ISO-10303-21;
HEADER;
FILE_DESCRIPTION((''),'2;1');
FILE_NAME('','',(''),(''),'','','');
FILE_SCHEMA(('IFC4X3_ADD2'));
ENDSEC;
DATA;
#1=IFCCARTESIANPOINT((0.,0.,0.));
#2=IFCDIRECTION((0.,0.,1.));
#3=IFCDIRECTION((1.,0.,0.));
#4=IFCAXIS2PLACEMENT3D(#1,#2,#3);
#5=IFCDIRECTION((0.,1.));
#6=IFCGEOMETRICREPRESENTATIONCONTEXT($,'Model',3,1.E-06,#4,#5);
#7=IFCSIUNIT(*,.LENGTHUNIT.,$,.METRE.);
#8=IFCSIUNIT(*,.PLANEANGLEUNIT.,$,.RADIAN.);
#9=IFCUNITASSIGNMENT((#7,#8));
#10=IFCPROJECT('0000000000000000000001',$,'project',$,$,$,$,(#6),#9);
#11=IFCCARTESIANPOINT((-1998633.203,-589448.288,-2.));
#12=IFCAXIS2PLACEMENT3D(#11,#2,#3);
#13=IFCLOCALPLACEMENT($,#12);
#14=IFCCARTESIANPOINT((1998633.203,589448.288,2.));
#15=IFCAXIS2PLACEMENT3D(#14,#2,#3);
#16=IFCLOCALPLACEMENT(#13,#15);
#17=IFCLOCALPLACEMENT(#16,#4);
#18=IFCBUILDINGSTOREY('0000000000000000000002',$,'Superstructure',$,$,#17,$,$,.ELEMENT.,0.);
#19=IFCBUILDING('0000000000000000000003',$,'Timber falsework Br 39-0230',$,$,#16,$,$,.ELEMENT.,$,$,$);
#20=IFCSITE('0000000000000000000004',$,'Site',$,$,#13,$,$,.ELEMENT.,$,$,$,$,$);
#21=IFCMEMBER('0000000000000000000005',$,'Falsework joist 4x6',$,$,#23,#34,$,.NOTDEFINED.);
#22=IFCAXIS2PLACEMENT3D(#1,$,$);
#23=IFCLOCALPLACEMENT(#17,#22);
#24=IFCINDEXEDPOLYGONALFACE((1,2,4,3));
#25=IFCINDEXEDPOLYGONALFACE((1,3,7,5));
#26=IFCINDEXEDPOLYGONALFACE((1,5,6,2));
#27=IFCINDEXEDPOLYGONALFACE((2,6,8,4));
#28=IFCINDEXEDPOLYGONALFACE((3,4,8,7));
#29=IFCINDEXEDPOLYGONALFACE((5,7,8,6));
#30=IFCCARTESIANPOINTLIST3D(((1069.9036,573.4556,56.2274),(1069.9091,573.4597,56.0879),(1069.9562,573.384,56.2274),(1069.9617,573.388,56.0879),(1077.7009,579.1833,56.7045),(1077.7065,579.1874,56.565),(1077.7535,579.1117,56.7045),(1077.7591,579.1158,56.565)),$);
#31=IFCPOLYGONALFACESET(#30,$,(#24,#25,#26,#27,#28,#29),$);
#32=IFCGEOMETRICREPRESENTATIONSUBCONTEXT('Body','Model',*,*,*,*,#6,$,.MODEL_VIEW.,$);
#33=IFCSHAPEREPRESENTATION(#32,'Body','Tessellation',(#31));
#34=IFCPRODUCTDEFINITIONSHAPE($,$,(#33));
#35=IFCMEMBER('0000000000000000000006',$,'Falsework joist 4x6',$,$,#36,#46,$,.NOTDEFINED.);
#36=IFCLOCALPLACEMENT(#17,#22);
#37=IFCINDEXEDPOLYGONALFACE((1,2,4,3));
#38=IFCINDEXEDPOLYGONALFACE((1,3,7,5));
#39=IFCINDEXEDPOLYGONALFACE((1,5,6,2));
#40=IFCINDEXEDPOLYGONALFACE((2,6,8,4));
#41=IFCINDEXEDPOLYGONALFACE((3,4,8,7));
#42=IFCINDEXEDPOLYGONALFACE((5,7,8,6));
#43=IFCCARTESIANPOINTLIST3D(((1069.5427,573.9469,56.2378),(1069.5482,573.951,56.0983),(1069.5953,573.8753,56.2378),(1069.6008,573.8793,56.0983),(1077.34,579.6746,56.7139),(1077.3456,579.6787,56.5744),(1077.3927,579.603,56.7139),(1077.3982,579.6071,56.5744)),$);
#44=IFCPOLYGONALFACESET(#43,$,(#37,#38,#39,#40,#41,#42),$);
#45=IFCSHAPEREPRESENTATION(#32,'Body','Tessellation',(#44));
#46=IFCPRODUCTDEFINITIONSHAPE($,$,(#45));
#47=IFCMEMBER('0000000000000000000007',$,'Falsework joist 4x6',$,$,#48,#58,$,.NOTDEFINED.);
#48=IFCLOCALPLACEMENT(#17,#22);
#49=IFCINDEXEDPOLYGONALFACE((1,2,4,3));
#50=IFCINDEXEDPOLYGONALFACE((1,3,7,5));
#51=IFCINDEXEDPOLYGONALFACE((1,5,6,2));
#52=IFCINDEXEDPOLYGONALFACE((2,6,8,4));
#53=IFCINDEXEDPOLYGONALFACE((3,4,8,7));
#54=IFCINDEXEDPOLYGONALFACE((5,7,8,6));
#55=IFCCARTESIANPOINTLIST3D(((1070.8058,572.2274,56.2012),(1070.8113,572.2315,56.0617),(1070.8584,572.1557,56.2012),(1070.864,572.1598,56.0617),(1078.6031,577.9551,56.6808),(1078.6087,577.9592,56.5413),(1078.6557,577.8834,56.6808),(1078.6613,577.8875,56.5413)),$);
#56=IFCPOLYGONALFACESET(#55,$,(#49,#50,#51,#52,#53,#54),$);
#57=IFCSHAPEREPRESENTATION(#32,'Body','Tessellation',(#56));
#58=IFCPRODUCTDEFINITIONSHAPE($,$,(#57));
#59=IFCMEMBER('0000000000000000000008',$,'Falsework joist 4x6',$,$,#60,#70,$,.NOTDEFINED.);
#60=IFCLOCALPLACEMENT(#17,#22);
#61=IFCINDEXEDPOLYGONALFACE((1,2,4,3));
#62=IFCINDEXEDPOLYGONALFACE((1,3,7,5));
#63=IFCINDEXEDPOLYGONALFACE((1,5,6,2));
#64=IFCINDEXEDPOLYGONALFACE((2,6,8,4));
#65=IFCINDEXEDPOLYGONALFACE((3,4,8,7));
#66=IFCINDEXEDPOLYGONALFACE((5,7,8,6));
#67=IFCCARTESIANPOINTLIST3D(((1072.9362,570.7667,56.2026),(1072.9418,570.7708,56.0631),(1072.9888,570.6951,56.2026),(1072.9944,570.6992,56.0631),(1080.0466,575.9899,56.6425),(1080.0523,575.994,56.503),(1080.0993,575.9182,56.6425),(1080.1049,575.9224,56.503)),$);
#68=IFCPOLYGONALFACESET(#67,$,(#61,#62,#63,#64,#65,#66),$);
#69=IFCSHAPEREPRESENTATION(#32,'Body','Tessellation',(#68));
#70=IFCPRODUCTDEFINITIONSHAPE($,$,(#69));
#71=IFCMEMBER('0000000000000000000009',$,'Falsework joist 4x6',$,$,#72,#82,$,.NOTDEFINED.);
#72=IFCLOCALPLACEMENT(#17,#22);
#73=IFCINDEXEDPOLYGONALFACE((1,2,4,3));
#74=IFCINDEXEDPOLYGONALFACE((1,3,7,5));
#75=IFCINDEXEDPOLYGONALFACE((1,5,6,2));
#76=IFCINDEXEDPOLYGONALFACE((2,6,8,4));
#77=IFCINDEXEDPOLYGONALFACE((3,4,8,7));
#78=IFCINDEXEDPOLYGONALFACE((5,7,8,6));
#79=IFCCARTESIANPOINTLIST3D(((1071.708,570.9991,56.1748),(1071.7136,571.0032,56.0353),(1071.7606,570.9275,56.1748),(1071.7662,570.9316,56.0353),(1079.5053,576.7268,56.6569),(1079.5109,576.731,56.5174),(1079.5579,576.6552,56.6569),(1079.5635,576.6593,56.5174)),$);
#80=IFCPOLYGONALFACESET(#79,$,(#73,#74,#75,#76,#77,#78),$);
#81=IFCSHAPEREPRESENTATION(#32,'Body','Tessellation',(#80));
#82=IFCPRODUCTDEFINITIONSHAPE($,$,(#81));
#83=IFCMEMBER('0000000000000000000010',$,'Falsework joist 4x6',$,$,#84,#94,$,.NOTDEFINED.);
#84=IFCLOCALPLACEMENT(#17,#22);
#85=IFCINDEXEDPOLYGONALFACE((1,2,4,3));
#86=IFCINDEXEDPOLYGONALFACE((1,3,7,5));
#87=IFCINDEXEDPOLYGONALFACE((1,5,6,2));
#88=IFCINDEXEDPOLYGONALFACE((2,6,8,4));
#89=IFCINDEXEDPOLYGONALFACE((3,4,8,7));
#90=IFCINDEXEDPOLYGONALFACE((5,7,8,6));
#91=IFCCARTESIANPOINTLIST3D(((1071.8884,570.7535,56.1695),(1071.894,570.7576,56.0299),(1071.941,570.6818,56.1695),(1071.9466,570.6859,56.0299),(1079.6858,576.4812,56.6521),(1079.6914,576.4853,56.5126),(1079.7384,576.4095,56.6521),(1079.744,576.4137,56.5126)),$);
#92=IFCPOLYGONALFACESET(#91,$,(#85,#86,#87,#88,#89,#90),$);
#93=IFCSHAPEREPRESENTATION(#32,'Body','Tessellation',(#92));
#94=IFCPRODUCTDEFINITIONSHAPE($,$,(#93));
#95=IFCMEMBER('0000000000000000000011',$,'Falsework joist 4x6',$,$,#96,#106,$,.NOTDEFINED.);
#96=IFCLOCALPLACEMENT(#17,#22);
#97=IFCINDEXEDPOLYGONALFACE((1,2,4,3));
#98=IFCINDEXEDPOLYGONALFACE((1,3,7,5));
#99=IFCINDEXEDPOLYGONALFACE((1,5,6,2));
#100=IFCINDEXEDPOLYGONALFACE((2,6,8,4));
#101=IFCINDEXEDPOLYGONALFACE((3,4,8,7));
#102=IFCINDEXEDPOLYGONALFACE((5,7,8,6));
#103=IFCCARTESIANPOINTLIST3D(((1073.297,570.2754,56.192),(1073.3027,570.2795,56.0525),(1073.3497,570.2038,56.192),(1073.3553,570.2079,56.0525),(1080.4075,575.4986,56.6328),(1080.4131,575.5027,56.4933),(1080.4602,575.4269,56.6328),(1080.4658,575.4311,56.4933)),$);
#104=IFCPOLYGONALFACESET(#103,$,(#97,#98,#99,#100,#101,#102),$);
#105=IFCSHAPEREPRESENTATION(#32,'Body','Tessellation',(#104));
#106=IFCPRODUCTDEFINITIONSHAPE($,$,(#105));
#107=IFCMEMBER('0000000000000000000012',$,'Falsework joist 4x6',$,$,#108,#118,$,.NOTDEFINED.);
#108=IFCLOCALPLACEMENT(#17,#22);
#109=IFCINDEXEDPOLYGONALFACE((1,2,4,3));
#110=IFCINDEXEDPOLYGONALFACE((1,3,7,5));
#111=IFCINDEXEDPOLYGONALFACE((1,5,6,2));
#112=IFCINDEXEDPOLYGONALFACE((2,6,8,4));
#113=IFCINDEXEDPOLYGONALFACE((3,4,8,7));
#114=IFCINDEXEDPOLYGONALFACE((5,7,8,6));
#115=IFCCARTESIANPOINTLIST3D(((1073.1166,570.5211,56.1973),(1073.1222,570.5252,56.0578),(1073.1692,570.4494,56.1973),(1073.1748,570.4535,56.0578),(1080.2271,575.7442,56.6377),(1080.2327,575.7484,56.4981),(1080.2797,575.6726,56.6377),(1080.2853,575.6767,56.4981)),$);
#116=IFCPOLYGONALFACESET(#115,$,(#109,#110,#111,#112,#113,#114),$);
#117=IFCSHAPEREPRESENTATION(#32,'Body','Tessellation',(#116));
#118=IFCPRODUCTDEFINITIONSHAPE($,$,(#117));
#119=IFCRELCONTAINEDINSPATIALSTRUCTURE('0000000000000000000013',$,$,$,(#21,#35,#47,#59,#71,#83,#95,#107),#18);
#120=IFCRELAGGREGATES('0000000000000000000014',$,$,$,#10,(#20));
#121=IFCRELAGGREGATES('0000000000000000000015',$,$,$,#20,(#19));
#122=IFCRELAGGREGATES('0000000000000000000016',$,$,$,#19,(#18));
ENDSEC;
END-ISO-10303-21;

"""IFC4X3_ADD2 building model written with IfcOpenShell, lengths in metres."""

from ifc_helpers import new_model, si_unit, direction, frame, frame_2d, origin, origin_with_axes, place, context, subcontext, project, spatial, rectangle, extrude, element, save


model = new_model("IFC4X3_ADD2")

# Units and contexts
model_context = context("Model", 3, precision=1e-06, world=origin_with_axes(), true_north=direction((0.0, 1.0)))
body_context = subcontext(model_context, "Body", "Model", "MODEL_VIEW")
ifc_project = project(units=[si_unit("LENGTHUNIT", "METRE"), si_unit("PLANEANGLEUNIT", "RADIAN")], contexts=[model_context])

# Site, building, storey
site_placement = place(None, frame((-1998633.203, -589448.288, -2.0), z_axis=(0.0, 0.0, 1.0), x_axis=(1.0, 0.0, 0.0)))
site = spatial("IfcSite", under=ifc_project, at=site_placement, Name="Site", CompositionType="ELEMENT")
building_placement = place(site_placement, frame((1998633.203, 589448.288, 2.0), z_axis=(0.0, 0.0, 1.0), x_axis=(1.0, 0.0, 0.0)))
building = spatial("IfcBuilding", under=site, at=building_placement, Name="Timber falsework Br 39-0230", CompositionType="ELEMENT")
storey_placement = place(building_placement, origin_with_axes())
storey = spatial("IfcBuildingStorey", under=building, at=storey_placement, Name="Superstructure", CompositionType="ELEMENT", Elevation=0.0)

# Members
member_1_placement = place(storey_placement, frame((1069.9354, 573.4239, 56.0879), z_axis=(0.80495, 0.591295, 0.049254), x_axis=(-0.592013, 0.805928, 0.0)))
element("IfcMember", 1, at=member_1_placement, inside=storey, Name="Falsework joist 4x6", PredefinedType="NOTDEFINED", context=body_context, shape_type="SweptSolid", body=[
    extrude(rectangle(XDim=0.0889, YDim=0.1397, at=frame_2d((0.0, 0.0698))), origin(), (0.0, 0.0, 1.0), 9.6868),
])
member_2_placement = place(storey_placement, frame((1069.5745, 573.9152, 56.0983), z_axis=(0.804954, 0.591298, 0.04915), x_axis=(-0.592013, 0.805928, 0.0)))
element("IfcMember", 2, at=member_2_placement, inside=storey, Name="Falsework joist 4x6", PredefinedType="NOTDEFINED", context=body_context, shape_type="SweptSolid", body=[
    extrude(rectangle(XDim=0.0889, YDim=0.1397, at=frame_2d((0.0, 0.0698))), origin(), (0.0, 0.0, 1.0), 9.6867),
])
member_3_placement = place(storey_placement, frame((1070.8376, 572.1956, 56.0617), z_axis=(0.80494, 0.591287, 0.049514), x_axis=(-0.592013, 0.805928, 0.0)))
element("IfcMember", 3, at=member_3_placement, inside=storey, Name="Falsework joist 4x6", PredefinedType="NOTDEFINED", context=body_context, shape_type="SweptSolid", body=[
    extrude(rectangle(XDim=0.0889, YDim=0.1397, at=frame_2d((0.0, 0.0698))), origin(), (0.0, 0.0, 1.0), 9.6869),
])
member_4_placement = place(storey_placement, frame((1072.9681, 570.735, 56.0631), z_axis=(0.804928, 0.591279, 0.049798), x_axis=(-0.592013, 0.805928, 0.0)))
element("IfcMember", 4, at=member_4_placement, inside=storey, Name="Falsework joist 4x6", PredefinedType="NOTDEFINED", context=body_context, shape_type="SweptSolid", body=[
    extrude(rectangle(XDim=0.0889, YDim=0.1397, at=frame_2d((0.0, 0.0698))), origin(), (0.0, 0.0, 1.0), 8.8337),
])
member_5_placement = place(storey_placement, frame((1071.7399, 570.9674, 56.0353), z_axis=(0.804929, 0.591279, 0.049773), x_axis=(-0.592013, 0.805928, 0.0)))
element("IfcMember", 5, at=member_5_placement, inside=storey, Name="Falsework joist 4x6", PredefinedType="NOTDEFINED", context=body_context, shape_type="SweptSolid", body=[
    extrude(rectangle(XDim=0.0889, YDim=0.1397, at=frame_2d((0.0, 0.0698))), origin(), (0.0, 0.0, 1.0), 9.687),
])
member_6_placement = place(storey_placement, frame((1071.9203, 570.7218, 56.0299), z_axis=(0.804927, 0.591278, 0.049825), x_axis=(-0.592013, 0.805928, 0.0)))
element("IfcMember", 6, at=member_6_placement, inside=storey, Name="Falsework joist 4x6", PredefinedType="NOTDEFINED", context=body_context, shape_type="SweptSolid", body=[
    extrude(rectangle(XDim=0.0889, YDim=0.1397, at=frame_2d((0.0, 0.0698))), origin(), (0.0, 0.0, 1.0), 9.687),
])
member_7_placement = place(storey_placement, frame((1073.329, 570.2437, 56.0525), z_axis=(0.804924, 0.591276, 0.049902), x_axis=(-0.592013, 0.805928, 0.0)))
element("IfcMember", 7, at=member_7_placement, inside=storey, Name="Falsework joist 4x6", PredefinedType="NOTDEFINED", context=body_context, shape_type="SweptSolid", body=[
    extrude(rectangle(XDim=0.0889, YDim=0.1397, at=frame_2d((0.0, 0.0698))), origin(), (0.0, 0.0, 1.0), 8.8337),
])
member_8_placement = place(storey_placement, frame((1073.1485, 570.4894, 56.0578), z_axis=(0.804926, 0.591277, 0.04985), x_axis=(-0.592013, 0.805928, 0.0)))
element("IfcMember", 8, at=member_8_placement, inside=storey, Name="Falsework joist 4x6", PredefinedType="NOTDEFINED", context=body_context, shape_type="SweptSolid", body=[
    extrude(rectangle(XDim=0.0889, YDim=0.1397, at=frame_2d((0.0, 0.0698))), origin(), (0.0, 0.0, 1.0), 8.8337),
])

save(model, "model.ifc")
